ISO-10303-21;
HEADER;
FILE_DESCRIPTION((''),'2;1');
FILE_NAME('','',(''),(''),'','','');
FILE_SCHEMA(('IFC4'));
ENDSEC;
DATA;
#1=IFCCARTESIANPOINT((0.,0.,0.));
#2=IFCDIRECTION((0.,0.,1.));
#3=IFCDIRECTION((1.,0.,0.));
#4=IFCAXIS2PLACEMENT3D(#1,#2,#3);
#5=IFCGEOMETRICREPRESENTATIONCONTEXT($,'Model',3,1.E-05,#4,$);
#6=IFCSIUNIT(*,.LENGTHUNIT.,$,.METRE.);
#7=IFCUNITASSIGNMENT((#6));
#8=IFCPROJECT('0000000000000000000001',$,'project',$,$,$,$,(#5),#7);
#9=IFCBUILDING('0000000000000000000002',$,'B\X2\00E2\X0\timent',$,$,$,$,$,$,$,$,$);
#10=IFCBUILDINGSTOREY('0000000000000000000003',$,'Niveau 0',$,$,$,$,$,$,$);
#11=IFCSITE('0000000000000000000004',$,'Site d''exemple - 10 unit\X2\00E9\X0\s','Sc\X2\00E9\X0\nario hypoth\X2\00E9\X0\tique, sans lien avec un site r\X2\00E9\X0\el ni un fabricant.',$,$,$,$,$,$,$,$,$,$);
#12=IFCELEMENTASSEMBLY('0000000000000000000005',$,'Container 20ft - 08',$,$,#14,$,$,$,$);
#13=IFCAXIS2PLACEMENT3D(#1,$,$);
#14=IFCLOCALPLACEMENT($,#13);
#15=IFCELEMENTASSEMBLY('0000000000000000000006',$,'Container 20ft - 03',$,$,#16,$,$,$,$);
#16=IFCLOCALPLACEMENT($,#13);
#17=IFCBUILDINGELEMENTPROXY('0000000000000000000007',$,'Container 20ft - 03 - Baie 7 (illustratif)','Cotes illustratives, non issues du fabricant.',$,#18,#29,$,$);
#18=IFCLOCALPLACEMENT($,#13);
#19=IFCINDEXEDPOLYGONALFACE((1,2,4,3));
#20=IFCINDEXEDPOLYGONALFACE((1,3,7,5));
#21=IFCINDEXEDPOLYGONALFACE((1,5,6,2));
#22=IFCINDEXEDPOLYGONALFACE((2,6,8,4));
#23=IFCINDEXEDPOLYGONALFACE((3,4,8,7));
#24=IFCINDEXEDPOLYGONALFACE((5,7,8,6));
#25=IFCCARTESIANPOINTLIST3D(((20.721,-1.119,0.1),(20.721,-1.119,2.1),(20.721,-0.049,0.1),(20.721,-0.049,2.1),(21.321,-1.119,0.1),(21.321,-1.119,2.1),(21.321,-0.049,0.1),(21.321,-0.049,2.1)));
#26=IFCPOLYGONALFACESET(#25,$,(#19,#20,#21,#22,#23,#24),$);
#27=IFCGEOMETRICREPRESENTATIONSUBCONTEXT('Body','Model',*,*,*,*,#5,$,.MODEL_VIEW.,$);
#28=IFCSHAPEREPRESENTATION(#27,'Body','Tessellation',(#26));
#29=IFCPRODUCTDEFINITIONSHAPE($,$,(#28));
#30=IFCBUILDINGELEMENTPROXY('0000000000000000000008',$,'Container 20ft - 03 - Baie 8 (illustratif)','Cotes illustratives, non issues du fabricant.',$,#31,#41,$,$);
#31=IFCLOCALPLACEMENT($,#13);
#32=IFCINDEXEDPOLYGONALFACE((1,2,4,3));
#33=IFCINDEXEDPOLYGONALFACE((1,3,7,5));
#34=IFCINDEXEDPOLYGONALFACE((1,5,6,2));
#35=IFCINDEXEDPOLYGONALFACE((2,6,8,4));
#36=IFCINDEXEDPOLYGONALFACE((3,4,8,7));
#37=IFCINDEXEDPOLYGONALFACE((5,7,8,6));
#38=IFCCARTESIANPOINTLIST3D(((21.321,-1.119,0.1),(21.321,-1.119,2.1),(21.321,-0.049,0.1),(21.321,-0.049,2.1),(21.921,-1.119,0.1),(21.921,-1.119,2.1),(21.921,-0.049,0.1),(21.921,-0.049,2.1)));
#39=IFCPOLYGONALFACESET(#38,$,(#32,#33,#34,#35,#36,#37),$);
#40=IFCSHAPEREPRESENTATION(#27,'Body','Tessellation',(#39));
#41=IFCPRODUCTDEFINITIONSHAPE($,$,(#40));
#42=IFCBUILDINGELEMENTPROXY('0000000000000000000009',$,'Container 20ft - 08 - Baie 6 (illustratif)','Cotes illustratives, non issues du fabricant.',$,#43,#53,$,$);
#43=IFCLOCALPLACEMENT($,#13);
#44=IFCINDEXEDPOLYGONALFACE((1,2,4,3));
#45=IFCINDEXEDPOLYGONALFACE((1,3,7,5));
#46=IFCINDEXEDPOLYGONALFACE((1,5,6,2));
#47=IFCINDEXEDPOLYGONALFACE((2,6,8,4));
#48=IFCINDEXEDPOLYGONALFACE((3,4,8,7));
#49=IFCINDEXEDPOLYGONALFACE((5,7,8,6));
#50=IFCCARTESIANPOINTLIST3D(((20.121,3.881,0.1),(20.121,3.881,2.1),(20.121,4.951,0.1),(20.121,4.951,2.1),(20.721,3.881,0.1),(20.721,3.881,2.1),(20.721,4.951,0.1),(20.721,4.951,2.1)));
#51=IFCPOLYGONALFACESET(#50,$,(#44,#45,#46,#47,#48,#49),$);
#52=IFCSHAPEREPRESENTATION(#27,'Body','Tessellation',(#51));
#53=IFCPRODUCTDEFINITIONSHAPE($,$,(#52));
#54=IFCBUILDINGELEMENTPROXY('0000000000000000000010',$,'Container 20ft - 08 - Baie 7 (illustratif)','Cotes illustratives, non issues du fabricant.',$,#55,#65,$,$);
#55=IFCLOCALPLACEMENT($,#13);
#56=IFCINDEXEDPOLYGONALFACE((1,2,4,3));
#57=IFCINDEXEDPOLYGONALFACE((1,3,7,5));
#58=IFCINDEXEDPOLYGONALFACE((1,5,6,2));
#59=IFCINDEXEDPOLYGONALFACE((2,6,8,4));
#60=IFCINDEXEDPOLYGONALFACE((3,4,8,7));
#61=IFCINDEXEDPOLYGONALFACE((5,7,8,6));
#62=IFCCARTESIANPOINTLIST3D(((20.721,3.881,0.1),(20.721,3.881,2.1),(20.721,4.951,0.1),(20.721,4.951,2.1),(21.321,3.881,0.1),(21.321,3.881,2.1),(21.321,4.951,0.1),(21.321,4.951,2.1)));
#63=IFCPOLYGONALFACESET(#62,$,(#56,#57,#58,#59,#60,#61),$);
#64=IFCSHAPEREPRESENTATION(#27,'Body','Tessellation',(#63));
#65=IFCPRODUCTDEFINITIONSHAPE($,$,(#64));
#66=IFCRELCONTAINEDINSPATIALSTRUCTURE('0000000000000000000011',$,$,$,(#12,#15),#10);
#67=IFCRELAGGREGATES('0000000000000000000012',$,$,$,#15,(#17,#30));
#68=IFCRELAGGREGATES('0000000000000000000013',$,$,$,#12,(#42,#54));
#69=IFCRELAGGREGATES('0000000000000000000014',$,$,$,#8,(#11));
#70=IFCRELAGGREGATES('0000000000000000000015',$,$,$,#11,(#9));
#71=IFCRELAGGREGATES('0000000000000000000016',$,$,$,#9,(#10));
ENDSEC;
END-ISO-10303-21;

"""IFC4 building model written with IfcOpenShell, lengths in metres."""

from ifc_helpers import new_model, si_unit, frame, origin_with_axes, place, context, subcontext, project, spatial, rectangle, extrude, element, aggregate, save


model = new_model("IFC4")

# Units and contexts
model_context = context("Model", 3, precision=1e-05, world=origin_with_axes())
body_context = subcontext(model_context, "Body", "Model", "MODEL_VIEW")
ifc_project = project(units=[si_unit("LENGTHUNIT", "METRE")], contexts=[model_context])

# Site, building, storey
site = spatial("IfcSite", under=ifc_project, Name="Site d'exemple - 10 unités", Description="Scénario hypothétique, sans lien avec un site réel ni un fabricant.")
building = spatial("IfcBuilding", under=site, Name="Bâtiment")
storey = spatial("IfcBuildingStorey", under=building, Name="Niveau 0")

# Element assembly
assembly_1 = element("IfcElementAssembly", 1, inside=storey, Name="Container 20ft - 08")

# Element assembly
assembly_2 = element("IfcElementAssembly", 2, inside=storey, Name="Container 20ft - 03")

# Building element proxies
proxy_1_placement = place(None, frame((21.021, -0.584, 0.1), z_axis=(0.0, 0.0, 1.0), x_axis=(1.0, 0.0, 0.0)))
proxy_1 = element("IfcBuildingElementProxy", 3, at=proxy_1_placement, Name="Container 20ft - 03 - Baie 7 (illustratif)", Description="Cotes illustratives, non issues du fabricant.", context=body_context, shape_type="SweptSolid", body=[
    extrude(rectangle(XDim=0.6, YDim=1.07), origin_with_axes(), (0.0, 0.0, 1.0), 2.0),
])
proxy_2_placement = place(None, frame((21.621, -0.584, 0.1), z_axis=(0.0, 0.0, 1.0), x_axis=(1.0, 0.0, 0.0)))
proxy_2 = element("IfcBuildingElementProxy", 4, at=proxy_2_placement, Name="Container 20ft - 03 - Baie 8 (illustratif)", Description="Cotes illustratives, non issues du fabricant.", context=body_context, shape_type="SweptSolid", body=[
    extrude(rectangle(XDim=0.6, YDim=1.07), origin_with_axes(), (0.0, 0.0, 1.0), 2.0),
])
aggregate(assembly_2, [proxy_1, proxy_2])
proxy_3_placement = place(None, frame((20.421, 4.416, 0.1), z_axis=(0.0, 0.0, 1.0), x_axis=(1.0, 0.0, 0.0)))
proxy_3 = element("IfcBuildingElementProxy", 5, at=proxy_3_placement, Name="Container 20ft - 08 - Baie 6 (illustratif)", Description="Cotes illustratives, non issues du fabricant.", context=body_context, shape_type="SweptSolid", body=[
    extrude(rectangle(XDim=0.6, YDim=1.07), origin_with_axes(), (0.0, 0.0, 1.0), 2.0),
])
proxy_4_placement = place(None, frame((21.021, 4.416, 0.1), z_axis=(0.0, 0.0, 1.0), x_axis=(1.0, 0.0, 0.0)))
proxy_4 = element("IfcBuildingElementProxy", 6, at=proxy_4_placement, Name="Container 20ft - 08 - Baie 7 (illustratif)", Description="Cotes illustratives, non issues du fabricant.", context=body_context, shape_type="SweptSolid", body=[
    extrude(rectangle(XDim=0.6, YDim=1.07), origin_with_axes(), (0.0, 0.0, 1.0), 2.0),
])
aggregate(assembly_1, [proxy_3, proxy_4])

save(model, "model.ifc")
